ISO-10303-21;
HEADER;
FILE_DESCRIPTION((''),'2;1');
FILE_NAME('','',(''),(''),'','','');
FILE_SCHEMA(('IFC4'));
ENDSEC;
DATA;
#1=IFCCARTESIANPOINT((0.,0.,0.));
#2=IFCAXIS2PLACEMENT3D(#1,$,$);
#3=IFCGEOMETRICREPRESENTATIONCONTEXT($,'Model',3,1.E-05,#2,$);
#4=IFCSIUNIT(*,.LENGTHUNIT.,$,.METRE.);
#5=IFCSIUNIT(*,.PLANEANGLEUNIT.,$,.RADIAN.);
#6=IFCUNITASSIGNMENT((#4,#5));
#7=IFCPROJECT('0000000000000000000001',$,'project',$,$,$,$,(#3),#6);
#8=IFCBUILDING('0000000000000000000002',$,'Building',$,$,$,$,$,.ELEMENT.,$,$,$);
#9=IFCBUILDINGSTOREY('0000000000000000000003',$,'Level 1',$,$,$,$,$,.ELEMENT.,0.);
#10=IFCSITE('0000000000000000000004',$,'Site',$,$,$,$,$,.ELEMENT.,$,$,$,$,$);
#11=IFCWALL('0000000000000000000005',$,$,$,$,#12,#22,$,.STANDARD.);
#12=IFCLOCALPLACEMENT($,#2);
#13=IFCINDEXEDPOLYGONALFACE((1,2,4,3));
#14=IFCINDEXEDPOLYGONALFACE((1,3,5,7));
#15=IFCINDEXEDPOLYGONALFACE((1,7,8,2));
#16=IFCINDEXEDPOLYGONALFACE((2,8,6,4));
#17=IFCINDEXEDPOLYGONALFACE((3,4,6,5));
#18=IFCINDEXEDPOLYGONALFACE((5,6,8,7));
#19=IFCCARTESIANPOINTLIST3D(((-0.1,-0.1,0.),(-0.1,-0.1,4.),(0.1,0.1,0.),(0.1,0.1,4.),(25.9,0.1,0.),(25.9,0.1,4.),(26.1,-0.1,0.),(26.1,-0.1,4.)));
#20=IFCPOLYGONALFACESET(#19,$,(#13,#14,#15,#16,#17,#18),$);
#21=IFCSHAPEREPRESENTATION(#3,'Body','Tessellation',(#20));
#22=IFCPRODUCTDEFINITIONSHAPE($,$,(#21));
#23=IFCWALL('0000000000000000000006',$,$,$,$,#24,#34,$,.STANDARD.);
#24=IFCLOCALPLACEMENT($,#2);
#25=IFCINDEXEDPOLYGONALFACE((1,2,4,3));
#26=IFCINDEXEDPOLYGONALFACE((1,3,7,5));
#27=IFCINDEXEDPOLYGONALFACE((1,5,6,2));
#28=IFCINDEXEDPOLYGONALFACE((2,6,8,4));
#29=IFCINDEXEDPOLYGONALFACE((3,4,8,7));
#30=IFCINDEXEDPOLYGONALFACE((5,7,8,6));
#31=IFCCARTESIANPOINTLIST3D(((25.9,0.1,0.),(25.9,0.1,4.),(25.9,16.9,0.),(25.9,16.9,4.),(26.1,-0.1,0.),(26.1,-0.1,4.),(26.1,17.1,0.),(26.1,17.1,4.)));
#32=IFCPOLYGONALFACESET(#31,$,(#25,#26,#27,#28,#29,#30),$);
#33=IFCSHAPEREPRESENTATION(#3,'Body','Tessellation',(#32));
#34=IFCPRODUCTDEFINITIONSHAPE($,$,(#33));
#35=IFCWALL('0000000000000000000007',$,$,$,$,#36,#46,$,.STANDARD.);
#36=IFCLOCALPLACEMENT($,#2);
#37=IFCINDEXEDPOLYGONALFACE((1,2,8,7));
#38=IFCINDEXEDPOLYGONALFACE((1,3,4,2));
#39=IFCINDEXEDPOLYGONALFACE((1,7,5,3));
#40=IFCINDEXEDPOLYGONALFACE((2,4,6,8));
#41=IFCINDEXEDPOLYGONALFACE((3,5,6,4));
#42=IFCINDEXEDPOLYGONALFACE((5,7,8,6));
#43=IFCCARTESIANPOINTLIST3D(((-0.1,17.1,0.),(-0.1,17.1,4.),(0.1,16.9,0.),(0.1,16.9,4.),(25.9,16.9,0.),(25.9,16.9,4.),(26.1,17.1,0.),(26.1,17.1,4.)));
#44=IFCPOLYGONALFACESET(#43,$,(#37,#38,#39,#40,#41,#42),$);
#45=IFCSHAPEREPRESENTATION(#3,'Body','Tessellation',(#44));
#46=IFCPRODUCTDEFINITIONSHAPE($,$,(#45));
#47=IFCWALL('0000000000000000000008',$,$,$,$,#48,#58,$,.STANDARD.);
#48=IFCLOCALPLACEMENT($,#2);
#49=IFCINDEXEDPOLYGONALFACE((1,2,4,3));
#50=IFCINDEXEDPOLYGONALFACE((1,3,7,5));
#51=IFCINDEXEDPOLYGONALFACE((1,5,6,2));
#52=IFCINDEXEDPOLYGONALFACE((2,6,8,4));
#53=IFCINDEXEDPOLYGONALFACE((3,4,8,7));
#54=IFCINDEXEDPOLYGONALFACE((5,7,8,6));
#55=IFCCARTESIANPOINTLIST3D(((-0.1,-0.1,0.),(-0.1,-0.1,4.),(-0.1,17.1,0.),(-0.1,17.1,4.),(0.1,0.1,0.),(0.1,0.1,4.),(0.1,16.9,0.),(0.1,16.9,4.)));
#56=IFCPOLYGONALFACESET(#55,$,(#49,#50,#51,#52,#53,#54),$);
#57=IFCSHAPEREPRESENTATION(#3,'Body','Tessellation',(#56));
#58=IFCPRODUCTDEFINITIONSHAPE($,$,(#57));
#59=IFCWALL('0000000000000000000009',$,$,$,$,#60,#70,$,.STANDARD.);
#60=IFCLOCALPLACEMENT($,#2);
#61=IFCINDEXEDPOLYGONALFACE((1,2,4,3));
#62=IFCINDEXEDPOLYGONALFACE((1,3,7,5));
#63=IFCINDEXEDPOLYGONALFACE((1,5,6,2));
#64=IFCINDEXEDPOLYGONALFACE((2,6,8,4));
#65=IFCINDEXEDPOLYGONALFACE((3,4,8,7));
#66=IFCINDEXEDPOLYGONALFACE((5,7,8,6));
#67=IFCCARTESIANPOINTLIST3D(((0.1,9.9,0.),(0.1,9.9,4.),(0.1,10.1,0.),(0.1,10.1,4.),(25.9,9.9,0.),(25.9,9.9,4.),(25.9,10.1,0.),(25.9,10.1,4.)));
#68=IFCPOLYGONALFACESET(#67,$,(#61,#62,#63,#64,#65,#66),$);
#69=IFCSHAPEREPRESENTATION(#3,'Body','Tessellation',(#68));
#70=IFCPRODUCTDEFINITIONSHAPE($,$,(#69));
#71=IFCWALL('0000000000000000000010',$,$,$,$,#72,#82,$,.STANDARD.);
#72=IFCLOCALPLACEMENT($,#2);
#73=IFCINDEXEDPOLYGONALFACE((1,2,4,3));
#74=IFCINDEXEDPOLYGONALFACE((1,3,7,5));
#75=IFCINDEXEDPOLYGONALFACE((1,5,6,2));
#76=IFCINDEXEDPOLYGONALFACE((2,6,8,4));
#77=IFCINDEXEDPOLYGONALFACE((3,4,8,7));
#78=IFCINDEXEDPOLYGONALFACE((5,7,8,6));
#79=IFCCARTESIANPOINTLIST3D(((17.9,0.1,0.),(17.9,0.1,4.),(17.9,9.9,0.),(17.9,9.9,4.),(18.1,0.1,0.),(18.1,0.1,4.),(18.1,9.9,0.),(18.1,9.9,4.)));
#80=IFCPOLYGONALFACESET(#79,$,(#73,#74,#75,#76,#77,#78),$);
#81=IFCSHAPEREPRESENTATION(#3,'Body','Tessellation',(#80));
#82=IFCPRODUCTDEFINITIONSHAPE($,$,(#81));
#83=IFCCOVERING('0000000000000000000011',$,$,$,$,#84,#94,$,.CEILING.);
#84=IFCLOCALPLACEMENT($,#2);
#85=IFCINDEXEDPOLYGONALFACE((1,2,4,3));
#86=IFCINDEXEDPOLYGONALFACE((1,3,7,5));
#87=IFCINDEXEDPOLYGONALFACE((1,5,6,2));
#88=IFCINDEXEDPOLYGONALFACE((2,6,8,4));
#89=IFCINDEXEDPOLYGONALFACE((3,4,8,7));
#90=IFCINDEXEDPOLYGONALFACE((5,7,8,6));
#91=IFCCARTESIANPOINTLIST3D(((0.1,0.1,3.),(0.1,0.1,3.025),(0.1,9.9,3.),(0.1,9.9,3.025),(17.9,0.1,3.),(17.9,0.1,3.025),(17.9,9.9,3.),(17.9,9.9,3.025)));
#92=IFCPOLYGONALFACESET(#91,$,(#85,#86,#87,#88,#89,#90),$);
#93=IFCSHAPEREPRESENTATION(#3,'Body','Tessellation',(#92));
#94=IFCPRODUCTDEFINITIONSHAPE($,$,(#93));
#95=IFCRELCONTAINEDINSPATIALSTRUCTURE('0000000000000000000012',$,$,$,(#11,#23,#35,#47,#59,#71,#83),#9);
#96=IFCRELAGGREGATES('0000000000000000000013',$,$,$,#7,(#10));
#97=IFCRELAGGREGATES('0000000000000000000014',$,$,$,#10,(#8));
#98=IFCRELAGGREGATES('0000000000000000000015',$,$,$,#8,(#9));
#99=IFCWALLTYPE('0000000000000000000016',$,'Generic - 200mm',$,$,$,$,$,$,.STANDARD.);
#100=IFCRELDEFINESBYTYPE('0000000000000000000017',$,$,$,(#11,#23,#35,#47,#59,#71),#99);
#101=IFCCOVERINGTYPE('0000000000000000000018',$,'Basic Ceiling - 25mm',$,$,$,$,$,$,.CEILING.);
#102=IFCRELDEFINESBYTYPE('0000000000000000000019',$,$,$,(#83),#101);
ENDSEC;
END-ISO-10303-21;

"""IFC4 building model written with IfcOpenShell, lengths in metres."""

from ifc_helpers import new_model, si_unit, frame, frame_2d, origin, origin_with_axes, place, context, project, spatial, polyline, rectangle, outline, extrude, type_object, element, save


model = new_model("IFC4")

# Units and contexts
model_context = context("Model", 3, precision=1e-05, world=origin())
ifc_project = project(units=[si_unit("LENGTHUNIT", "METRE"), si_unit("PLANEANGLEUNIT", "RADIAN")], contexts=[model_context])

# Site, building, storey
site = spatial("IfcSite", under=ifc_project, Name="Site", CompositionType="ELEMENT")
building = spatial("IfcBuilding", under=site, Name="Building", CompositionType="ELEMENT")
storey = spatial("IfcBuildingStorey", under=building, Name="Level 1", CompositionType="ELEMENT", Elevation=0.0)

# Walls
wall_type = type_object("IfcWallType", Name="Generic - 200mm", PredefinedType="STANDARD")
wall_1_placement = place(None, origin_with_axes())
element("IfcWall", 1, at=wall_1_placement, inside=storey, type_object=wall_type, PredefinedType="STANDARD", context=model_context, shape_type="SweptSolid", body=[
    extrude(outline(polyline([(-0.1, -0.1), (26.1, -0.1), (25.9, 0.1), (0.1, 0.1), (-0.1, -0.1)])), origin(), (0.0, 0.0, 1.0), 4.0),
])
wall_2_placement = place(None, frame((26.0, 0.0, 0.0), z_axis=(0.0, 0.0, 1.0), x_axis=(0.0, 1.0, 0.0)))
element("IfcWall", 2, at=wall_2_placement, inside=storey, type_object=wall_type, PredefinedType="STANDARD", context=model_context, shape_type="SweptSolid", body=[
    extrude(outline(polyline([(-0.1, -0.1), (17.1, -0.1), (16.9, 0.1), (0.1, 0.1), (-0.1, -0.1)])), origin(), (0.0, 0.0, 1.0), 4.0),
])
wall_3_placement = place(None, frame((26.0, 17.0, 0.0), z_axis=(0.0, 0.0, 1.0), x_axis=(-1.0, 0.0, 0.0)))
element("IfcWall", 3, at=wall_3_placement, inside=storey, type_object=wall_type, PredefinedType="STANDARD", context=model_context, shape_type="SweptSolid", body=[
    extrude(outline(polyline([(-0.1, -0.1), (26.1, -0.1), (25.9, 0.1), (0.1, 0.1), (-0.1, -0.1)])), origin(), (0.0, 0.0, 1.0), 4.0),
])
wall_4_placement = place(None, frame((0.0, 17.0, 0.0), z_axis=(0.0, 0.0, 1.0), x_axis=(0.0, -1.0, 0.0)))
element("IfcWall", 4, at=wall_4_placement, inside=storey, type_object=wall_type, PredefinedType="STANDARD", context=model_context, shape_type="SweptSolid", body=[
    extrude(outline(polyline([(-0.1, -0.1), (17.1, -0.1), (16.9, 0.1), (0.1, 0.1), (-0.1, -0.1)])), origin(), (0.0, 0.0, 1.0), 4.0),
])
wall_5_placement = place(None, frame((0.1, 10.0, 0.0), z_axis=(0.0, 0.0, 1.0), x_axis=(1.0, 0.0, 0.0)))
element("IfcWall", 5, at=wall_5_placement, inside=storey, type_object=wall_type, PredefinedType="STANDARD", context=model_context, shape_type="SweptSolid", body=[
    extrude(rectangle(XDim=25.8, YDim=0.2, at=frame_2d((12.9, 0.0))), origin(), (0.0, 0.0, 1.0), 4.0),
])
wall_6_placement = place(None, frame((18.0, 0.1, 0.0), z_axis=(0.0, 0.0, 1.0), x_axis=(0.0, 1.0, 0.0)))
element("IfcWall", 6, at=wall_6_placement, inside=storey, type_object=wall_type, PredefinedType="STANDARD", context=model_context, shape_type="SweptSolid", body=[
    extrude(rectangle(XDim=9.8, YDim=0.2, at=frame_2d((4.9, 0.0))), origin(), (0.0, 0.0, 1.0), 4.0),
])

# Covering
covering_type = type_object("IfcCoveringType", Name="Basic Ceiling - 25mm", PredefinedType="CEILING")
covering_placement = place(None, frame((0.0, 0.0, 3.025)))
element("IfcCovering", 7, at=covering_placement, inside=storey, type_object=covering_type, PredefinedType="CEILING", context=model_context, shape_type="SweptSolid", body=[
    extrude(outline(polyline([(0.1, 0.1), (17.9, 0.1), (17.9, 9.9), (0.1, 9.9), (0.1, 0.1)])), origin(), (0.0, 0.0, -1.0), 0.025),
])

save(model, "model.ifc")
